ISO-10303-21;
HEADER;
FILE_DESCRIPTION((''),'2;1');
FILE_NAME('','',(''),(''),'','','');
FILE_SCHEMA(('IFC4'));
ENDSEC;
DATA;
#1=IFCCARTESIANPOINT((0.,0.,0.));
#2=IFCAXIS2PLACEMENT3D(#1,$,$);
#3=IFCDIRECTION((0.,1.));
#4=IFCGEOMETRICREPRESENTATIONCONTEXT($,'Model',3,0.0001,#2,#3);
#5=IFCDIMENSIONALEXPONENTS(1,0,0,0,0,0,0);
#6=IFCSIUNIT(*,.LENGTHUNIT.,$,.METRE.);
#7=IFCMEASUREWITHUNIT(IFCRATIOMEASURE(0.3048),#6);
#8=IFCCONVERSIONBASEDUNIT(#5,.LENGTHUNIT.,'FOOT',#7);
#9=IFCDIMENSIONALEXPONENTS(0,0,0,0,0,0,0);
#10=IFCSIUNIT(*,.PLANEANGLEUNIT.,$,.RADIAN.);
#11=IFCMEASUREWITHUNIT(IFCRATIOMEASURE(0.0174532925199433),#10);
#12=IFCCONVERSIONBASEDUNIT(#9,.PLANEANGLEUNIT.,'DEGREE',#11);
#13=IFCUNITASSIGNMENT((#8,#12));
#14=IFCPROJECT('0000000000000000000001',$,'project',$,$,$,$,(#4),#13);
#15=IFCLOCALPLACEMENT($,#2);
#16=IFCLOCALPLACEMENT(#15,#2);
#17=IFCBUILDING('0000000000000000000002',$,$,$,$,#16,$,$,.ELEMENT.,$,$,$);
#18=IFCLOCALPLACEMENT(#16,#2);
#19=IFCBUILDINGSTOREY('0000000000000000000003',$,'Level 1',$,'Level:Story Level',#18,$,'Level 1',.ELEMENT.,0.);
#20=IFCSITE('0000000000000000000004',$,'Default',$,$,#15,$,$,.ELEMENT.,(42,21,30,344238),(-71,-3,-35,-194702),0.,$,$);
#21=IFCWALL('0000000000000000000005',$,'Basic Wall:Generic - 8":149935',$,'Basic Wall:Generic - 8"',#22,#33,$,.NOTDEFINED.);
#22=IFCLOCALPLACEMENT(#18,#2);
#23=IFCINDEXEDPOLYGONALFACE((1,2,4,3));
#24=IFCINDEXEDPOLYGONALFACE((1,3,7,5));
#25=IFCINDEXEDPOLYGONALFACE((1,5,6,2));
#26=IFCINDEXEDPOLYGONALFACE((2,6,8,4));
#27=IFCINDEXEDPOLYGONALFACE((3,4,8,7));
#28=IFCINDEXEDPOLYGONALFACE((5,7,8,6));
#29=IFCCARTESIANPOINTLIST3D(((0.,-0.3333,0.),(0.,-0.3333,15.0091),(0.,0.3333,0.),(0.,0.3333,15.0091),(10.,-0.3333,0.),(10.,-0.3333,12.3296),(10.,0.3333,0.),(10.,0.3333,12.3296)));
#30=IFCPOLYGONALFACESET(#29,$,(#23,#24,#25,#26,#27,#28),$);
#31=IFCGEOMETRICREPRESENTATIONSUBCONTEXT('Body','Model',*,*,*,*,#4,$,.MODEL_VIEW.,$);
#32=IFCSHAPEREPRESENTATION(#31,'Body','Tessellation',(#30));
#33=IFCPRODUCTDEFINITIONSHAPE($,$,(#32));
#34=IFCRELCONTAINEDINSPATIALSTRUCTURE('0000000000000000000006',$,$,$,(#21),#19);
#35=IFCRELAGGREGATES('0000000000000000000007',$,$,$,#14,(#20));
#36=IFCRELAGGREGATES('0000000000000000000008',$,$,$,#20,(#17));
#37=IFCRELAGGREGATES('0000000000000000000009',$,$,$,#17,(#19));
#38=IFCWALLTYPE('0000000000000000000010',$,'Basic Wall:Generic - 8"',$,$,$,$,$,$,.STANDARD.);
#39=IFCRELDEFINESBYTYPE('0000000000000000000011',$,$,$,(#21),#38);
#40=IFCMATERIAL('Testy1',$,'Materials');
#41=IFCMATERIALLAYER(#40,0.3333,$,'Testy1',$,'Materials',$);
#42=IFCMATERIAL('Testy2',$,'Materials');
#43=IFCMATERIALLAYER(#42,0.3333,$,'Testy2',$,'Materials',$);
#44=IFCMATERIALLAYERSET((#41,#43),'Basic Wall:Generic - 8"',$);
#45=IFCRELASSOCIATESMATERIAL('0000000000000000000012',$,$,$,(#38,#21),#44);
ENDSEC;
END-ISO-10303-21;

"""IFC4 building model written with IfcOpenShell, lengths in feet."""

from ifc_helpers import new_model, entity, si_unit, converted_unit, direction, frame, frame_2d, origin, place, context, subcontext, project, spatial, polyline, rectangle, extrude, clip, bounded_halfspace, material, layer, layer_set, layer_usage, type_object, element, save


model = new_model("IFC4")

# Units and contexts
model_context = context("Model", 3, precision=0.0001, world=origin(), true_north=direction((0.0, 1.0)))
body_context = subcontext(model_context, "Body", "Model", "MODEL_VIEW")
ifc_project = project(units=[converted_unit("LENGTHUNIT", "FOOT", entity("IfcRatioMeasure", 0.3048), si_unit("LENGTHUNIT", "METRE"), dimensions=[1, 0, 0, 0, 0, 0, 0]), converted_unit("PLANEANGLEUNIT", "DEGREE", entity("IfcRatioMeasure", 0.0174532925199433), si_unit("PLANEANGLEUNIT", "RADIAN"), dimensions=[0, 0, 0, 0, 0, 0, 0])], contexts=[model_context])

# Site, building, storey
site_placement = place(None, origin())
site = spatial("IfcSite", under=ifc_project, at=site_placement, Name="Default", CompositionType="ELEMENT", RefLatitude=(42, 21, 30, 344238), RefLongitude=(-71, -3, -35, -194702), RefElevation=0.0)
building_placement = place(site_placement, origin())
building = spatial("IfcBuilding", under=site, at=building_placement, CompositionType="ELEMENT")
storey_placement = place(building_placement, origin())
storey = spatial("IfcBuildingStorey", under=building, at=storey_placement, Name="Level 1", ObjectType="Level:Story Level", LongName="Level 1", CompositionType="ELEMENT", Elevation=0.0)

# Wall
ifc_material_1 = material(Name="Testy1", Category="Materials")
ifc_layer_1 = layer(ifc_material_1, 0.3333, Name="Testy1", Category="Materials")
ifc_material_2 = material(Name="Testy2", Category="Materials")
ifc_layer_2 = layer(ifc_material_2, 0.3333, Name="Testy2", Category="Materials")
ifc_layer_set = layer_set([ifc_layer_1, ifc_layer_2], Name="Basic Wall:Generic - 8\"")
ifc_layer_usage = layer_usage(ifc_layer_set, "AXIS2", "NEGATIVE", 0.3333)
wall_type = type_object("IfcWallType", Name="Basic Wall:Generic - 8\"", PredefinedType="STANDARD", material=ifc_layer_set)
wall_placement = place(storey_placement, origin())
element("IfcWall", 1, at=wall_placement, inside=storey, type_object=wall_type, material=ifc_layer_usage, Name="Basic Wall:Generic - 8\":149935", ObjectType="Basic Wall:Generic - 8\"", PredefinedType="NOTDEFINED", context=body_context, shape_type="Clipping", body=[
    clip(extrude(rectangle(XDim=10.0, YDim=0.6667, at=frame_2d((5.0, 0.0), x_axis=(-1.0, 0.0))), origin(), (0.0, 0.0, 1.0), 15.0091), bounded_halfspace(frame((0.0, -0.3333, 15.0091), z_axis=(0.258819, 0.0, 0.965926), x_axis=(0.0, 1.0, 0.0)), False, frame((0.0, -0.3333, 15.0091)), polyline([(0.0, 0.0), (10.0, 0.0), (10.0, 0.6667), (0.0, 0.6667), (0.0, 0.0)]))),
])

save(model, "model.ifc")
